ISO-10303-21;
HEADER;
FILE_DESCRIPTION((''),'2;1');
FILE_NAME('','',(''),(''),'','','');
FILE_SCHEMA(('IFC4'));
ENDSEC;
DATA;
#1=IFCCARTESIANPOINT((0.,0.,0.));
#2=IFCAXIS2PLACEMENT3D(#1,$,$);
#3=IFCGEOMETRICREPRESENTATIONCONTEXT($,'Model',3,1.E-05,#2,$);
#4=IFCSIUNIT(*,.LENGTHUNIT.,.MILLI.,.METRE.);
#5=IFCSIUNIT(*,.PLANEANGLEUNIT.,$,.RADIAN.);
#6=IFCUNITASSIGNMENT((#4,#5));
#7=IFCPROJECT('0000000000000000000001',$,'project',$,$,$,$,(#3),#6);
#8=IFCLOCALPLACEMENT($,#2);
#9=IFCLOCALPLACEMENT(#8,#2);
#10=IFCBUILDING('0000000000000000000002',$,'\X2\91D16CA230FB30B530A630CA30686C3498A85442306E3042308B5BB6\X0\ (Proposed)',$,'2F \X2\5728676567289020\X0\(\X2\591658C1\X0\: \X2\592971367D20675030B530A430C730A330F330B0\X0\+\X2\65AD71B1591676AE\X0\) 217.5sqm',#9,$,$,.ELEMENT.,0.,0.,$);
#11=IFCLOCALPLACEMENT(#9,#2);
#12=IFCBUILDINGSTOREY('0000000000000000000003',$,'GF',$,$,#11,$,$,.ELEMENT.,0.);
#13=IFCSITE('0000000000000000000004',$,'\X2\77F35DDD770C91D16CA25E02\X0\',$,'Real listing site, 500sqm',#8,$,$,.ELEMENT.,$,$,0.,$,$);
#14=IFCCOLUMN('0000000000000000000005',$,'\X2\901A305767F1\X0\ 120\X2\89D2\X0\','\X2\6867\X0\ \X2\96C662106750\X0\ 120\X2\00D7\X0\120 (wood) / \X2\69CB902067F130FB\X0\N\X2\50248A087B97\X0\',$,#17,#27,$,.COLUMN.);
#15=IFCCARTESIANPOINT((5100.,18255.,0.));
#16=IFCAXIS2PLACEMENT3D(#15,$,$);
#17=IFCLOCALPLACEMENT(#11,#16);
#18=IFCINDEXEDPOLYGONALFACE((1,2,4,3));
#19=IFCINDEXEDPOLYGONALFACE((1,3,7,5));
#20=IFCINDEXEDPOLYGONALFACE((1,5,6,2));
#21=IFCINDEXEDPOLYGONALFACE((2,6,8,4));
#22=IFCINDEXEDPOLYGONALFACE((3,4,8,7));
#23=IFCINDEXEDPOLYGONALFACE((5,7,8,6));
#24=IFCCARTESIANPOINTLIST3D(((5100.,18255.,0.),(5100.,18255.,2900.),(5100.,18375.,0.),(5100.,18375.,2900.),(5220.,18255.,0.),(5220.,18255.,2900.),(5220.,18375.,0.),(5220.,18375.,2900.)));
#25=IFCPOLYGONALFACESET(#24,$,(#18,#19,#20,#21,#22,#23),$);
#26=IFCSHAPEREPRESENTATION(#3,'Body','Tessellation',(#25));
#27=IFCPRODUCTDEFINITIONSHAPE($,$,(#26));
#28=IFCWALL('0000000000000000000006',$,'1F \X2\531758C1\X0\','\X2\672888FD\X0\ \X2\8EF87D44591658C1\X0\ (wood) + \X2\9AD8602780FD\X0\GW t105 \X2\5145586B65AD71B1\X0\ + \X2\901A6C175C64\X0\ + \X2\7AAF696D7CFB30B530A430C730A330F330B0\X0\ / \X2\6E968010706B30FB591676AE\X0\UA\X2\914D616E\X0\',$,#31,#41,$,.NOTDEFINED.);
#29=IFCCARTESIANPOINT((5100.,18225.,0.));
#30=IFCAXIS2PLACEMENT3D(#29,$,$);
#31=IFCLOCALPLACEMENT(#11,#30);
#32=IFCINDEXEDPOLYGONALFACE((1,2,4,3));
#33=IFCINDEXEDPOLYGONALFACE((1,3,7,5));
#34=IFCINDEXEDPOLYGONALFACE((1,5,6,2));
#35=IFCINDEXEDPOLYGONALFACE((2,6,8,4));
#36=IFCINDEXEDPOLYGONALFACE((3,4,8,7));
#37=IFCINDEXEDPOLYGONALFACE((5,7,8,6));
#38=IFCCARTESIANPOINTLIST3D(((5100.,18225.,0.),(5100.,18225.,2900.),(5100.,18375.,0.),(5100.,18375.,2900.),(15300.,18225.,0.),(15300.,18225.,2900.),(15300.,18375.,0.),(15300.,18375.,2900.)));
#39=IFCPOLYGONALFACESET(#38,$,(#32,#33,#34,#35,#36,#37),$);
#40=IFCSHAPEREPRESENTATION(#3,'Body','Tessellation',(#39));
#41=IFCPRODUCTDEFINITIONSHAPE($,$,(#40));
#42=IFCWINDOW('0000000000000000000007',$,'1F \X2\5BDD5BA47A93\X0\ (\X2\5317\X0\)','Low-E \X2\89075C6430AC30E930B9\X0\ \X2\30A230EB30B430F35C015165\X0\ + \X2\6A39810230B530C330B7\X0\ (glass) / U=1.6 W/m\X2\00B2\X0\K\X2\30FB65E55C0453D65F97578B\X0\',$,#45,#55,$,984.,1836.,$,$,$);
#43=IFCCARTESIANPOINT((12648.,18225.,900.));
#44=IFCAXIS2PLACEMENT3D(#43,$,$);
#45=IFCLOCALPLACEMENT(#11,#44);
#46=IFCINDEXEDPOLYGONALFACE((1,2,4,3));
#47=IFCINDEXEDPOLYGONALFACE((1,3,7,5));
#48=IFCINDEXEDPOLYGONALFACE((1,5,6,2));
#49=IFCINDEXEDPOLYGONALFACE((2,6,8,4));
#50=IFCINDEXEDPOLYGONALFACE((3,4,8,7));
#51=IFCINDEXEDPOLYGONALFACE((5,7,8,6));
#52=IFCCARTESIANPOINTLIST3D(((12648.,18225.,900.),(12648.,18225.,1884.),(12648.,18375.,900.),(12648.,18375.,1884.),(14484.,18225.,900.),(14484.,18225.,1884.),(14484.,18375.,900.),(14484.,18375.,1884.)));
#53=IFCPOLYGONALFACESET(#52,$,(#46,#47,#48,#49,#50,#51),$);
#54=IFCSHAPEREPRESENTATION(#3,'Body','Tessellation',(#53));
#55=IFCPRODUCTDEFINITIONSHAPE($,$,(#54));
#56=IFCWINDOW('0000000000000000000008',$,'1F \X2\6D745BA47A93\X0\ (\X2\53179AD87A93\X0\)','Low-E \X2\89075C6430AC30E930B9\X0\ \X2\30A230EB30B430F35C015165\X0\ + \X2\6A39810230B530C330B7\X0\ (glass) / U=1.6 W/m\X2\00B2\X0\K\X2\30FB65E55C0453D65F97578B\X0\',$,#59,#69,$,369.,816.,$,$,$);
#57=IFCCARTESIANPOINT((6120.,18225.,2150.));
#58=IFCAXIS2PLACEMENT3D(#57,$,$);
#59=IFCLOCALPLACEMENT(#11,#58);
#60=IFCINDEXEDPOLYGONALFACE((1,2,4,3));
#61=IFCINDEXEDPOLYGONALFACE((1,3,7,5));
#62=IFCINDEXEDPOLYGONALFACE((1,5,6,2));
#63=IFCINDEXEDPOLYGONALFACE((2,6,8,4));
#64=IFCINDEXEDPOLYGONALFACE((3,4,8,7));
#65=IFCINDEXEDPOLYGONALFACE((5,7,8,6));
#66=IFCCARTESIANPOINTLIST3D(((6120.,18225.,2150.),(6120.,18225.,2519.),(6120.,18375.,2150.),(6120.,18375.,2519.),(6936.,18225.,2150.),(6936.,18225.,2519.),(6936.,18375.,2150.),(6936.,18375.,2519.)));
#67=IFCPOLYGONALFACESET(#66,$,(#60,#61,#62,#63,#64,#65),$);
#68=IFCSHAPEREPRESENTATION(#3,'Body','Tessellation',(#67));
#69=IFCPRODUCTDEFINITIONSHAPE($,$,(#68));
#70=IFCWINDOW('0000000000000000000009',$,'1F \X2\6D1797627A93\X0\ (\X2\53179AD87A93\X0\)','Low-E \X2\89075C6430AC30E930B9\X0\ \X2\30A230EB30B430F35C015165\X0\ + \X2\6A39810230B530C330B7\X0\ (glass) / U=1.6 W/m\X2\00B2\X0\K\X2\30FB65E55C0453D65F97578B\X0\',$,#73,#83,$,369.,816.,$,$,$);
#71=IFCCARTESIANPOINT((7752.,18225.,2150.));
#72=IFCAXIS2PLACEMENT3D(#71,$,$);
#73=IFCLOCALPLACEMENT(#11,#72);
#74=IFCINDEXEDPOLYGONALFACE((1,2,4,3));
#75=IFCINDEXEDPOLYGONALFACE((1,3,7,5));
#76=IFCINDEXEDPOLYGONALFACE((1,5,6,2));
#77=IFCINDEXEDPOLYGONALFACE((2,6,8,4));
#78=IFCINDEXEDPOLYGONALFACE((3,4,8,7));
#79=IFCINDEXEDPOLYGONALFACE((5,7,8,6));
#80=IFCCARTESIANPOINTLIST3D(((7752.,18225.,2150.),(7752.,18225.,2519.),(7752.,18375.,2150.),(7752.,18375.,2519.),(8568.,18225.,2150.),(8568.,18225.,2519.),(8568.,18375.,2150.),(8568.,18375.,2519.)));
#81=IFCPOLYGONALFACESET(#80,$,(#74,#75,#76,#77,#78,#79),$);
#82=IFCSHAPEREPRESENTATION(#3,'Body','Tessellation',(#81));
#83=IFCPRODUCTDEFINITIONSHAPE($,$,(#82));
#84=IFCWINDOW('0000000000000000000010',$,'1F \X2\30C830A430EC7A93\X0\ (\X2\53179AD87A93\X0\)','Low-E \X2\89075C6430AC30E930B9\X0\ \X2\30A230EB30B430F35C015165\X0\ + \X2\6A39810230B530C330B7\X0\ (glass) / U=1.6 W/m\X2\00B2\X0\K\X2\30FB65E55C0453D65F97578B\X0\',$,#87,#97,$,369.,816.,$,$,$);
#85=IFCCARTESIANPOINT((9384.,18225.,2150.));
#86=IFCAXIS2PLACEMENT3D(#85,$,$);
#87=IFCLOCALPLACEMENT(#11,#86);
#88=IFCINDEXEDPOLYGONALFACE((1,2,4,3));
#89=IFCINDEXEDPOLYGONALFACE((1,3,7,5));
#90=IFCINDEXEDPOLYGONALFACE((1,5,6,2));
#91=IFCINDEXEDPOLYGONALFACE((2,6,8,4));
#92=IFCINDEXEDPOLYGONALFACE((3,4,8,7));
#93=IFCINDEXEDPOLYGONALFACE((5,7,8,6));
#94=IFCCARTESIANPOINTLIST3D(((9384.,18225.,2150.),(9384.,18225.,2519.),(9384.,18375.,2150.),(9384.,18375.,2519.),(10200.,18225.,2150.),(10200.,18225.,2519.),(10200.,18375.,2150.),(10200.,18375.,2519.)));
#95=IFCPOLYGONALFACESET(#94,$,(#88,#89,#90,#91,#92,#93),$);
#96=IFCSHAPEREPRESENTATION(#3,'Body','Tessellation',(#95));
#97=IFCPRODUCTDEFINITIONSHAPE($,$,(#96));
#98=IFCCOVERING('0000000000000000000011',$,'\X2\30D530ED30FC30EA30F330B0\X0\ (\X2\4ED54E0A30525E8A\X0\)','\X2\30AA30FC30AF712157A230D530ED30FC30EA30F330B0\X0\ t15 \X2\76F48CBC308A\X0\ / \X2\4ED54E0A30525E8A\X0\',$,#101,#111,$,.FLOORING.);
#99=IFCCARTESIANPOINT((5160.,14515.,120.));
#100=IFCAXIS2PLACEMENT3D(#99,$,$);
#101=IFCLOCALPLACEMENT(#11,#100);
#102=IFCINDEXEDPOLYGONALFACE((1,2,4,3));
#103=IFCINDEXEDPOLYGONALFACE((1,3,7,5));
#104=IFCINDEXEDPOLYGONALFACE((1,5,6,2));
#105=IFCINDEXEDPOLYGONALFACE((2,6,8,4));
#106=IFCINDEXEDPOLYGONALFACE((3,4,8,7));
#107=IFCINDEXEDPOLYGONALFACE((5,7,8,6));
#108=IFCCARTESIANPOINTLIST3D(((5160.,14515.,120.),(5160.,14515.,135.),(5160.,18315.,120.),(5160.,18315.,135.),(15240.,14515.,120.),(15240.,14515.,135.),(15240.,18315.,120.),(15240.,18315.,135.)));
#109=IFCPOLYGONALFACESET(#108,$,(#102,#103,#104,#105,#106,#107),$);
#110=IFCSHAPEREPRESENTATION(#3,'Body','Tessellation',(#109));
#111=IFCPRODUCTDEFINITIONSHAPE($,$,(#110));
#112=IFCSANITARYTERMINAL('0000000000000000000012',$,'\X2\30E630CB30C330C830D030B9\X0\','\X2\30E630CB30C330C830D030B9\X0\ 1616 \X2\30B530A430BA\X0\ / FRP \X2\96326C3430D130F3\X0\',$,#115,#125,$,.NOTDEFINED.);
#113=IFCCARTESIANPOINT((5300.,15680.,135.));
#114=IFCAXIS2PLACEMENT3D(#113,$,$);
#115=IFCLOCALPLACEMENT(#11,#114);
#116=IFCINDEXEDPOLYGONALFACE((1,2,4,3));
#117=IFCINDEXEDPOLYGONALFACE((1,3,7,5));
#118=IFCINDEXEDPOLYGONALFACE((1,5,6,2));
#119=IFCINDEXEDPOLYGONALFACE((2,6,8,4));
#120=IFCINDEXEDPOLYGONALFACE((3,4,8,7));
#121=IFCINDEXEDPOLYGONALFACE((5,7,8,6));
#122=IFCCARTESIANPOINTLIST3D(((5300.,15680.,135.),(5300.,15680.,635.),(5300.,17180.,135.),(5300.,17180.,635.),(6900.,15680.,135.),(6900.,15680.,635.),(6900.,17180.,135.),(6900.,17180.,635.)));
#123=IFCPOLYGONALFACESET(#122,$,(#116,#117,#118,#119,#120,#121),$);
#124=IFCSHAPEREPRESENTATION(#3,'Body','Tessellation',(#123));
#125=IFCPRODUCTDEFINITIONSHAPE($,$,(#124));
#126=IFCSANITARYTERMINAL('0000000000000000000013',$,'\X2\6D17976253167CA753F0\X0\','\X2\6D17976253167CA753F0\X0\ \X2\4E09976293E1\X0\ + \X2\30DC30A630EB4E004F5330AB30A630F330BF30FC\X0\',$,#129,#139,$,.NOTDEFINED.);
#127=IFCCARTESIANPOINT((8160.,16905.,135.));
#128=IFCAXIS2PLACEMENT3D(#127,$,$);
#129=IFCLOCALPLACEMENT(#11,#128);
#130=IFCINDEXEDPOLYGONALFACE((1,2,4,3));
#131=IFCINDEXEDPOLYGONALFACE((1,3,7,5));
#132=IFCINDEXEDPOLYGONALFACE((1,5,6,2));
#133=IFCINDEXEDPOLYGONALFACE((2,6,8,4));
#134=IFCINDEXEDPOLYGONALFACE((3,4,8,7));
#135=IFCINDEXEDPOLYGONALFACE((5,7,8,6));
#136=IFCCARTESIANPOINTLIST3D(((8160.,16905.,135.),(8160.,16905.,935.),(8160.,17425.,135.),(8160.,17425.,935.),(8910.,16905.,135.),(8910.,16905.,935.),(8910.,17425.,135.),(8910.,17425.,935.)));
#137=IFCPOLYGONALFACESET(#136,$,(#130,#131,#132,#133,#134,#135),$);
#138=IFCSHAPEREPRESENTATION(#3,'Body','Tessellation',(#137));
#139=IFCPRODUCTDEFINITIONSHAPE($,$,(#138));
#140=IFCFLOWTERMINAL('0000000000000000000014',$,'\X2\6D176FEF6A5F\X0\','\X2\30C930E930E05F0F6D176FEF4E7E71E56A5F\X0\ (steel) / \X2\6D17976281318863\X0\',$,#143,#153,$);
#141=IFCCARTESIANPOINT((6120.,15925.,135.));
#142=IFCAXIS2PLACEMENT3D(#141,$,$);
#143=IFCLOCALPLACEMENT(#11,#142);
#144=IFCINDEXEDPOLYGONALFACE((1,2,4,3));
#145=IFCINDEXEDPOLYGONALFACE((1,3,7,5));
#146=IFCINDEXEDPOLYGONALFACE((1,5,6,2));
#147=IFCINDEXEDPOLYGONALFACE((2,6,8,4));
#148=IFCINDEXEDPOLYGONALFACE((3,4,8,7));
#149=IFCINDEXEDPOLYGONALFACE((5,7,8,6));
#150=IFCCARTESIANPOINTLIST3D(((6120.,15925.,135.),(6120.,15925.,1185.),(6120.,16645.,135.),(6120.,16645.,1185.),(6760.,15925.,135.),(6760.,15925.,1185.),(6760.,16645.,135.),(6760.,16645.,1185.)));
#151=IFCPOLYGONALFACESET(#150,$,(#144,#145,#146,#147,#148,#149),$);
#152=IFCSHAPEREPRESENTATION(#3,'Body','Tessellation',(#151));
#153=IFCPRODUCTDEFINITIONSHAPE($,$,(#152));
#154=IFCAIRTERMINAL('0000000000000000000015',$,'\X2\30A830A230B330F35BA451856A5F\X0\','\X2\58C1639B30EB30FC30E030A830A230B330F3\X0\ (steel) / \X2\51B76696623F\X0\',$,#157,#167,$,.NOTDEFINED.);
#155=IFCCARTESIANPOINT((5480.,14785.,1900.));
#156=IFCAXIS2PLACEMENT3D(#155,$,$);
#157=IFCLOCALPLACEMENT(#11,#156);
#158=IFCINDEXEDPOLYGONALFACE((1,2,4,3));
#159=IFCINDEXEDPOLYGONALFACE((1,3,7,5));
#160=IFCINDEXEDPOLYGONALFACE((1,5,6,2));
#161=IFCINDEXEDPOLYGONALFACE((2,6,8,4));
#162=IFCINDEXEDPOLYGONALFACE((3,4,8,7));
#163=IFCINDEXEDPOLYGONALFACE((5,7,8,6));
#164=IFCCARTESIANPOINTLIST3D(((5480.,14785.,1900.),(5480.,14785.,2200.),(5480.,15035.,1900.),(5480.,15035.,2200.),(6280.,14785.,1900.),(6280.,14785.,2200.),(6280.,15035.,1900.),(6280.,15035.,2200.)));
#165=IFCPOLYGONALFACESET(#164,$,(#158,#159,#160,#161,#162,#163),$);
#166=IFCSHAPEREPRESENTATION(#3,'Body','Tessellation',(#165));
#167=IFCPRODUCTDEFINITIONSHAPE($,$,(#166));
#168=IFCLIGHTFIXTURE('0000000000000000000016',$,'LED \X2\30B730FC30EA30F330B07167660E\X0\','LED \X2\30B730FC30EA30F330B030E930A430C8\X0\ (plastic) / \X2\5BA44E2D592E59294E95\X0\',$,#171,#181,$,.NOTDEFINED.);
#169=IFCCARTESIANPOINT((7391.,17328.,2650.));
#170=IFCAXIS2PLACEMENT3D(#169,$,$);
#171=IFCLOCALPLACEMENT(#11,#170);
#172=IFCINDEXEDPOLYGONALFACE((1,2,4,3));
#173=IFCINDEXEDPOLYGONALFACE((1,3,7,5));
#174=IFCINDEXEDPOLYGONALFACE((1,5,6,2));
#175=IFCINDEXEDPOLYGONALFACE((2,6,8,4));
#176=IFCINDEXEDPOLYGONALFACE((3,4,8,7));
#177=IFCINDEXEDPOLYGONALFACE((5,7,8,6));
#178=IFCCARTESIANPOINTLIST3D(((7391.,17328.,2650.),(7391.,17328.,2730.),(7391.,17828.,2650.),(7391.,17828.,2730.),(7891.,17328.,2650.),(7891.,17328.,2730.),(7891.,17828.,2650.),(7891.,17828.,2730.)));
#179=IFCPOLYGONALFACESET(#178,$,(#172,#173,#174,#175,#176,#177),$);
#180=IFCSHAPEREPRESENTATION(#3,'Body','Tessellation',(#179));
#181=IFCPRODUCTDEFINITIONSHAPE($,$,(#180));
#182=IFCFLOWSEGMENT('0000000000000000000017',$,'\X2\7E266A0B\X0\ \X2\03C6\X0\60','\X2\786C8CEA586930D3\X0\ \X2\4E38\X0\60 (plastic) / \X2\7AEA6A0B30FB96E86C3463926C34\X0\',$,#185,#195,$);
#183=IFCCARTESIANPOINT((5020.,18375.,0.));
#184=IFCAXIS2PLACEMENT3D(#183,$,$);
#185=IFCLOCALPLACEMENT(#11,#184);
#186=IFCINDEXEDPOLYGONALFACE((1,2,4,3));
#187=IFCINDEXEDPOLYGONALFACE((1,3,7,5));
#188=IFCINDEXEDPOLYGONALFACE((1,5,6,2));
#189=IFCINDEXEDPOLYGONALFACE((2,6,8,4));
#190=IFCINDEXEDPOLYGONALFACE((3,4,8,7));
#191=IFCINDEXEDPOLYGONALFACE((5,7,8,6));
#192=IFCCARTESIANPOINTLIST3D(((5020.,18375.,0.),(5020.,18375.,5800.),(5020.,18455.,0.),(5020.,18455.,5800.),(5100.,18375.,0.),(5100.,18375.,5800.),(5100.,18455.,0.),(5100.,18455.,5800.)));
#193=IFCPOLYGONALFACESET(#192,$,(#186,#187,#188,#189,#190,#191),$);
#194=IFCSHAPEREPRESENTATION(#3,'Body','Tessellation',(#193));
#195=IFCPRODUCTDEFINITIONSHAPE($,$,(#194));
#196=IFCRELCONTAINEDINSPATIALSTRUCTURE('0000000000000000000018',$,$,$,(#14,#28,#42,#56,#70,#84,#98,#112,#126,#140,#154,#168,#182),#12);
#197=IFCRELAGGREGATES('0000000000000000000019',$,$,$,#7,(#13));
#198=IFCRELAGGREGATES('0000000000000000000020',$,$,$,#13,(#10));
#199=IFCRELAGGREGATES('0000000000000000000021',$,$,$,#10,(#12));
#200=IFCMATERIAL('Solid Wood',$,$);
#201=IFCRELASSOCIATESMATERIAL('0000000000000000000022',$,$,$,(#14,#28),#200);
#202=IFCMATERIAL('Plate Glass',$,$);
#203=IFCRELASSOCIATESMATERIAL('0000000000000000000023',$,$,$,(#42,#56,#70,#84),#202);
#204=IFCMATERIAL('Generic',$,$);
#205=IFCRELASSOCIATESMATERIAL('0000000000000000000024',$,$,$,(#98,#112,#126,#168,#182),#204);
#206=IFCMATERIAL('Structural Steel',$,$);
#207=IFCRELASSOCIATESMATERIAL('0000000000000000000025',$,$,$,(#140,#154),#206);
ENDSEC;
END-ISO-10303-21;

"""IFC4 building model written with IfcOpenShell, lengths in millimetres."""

from ifc_helpers import new_model, si_unit, frame, frame_2d, origin, place, context, project, spatial, rectangle, extrude, material, element, fill, save


model = new_model("IFC4")

# Units and contexts
model_context = context("Model", 3, precision=1e-05, world=origin())
ifc_project = project(units=[si_unit("LENGTHUNIT", "METRE", prefix="MILLI"), si_unit("PLANEANGLEUNIT", "RADIAN")], contexts=[model_context])

# Site, building, storey
site_placement = place(None, origin())
site = spatial("IfcSite", under=ifc_project, at=site_placement, Name="石川県金沢市", ObjectType="Real listing site, 500sqm", CompositionType="ELEMENT", RefElevation=0.0)
building_placement = place(site_placement, origin())
building = spatial("IfcBuilding", under=site, at=building_placement, Name="金沢・サウナと水風呂のある家 (Proposed)", ObjectType="2F 在来木造(外壁: 天然素材サイディング+断熱外皮) 217.5sqm", CompositionType="ELEMENT", ElevationOfRefHeight=0.0, ElevationOfTerrain=0.0)
storey_placement = place(building_placement, origin())
storey = spatial("IfcBuildingStorey", under=building, at=storey_placement, Name="GF", CompositionType="ELEMENT", Elevation=0.0)

# Column
ifc_material_1 = material(Name="Solid Wood")
column_1_placement = place(storey_placement, frame((5100.0, 18255.0, 0.0)))
element("IfcColumn", 1, at=column_1_placement, inside=storey, material=ifc_material_1, Name="通し柱 120角", Description="桧 集成材 120×120 (wood) / 構造柱・N値計算", PredefinedType="COLUMN", context=model_context, shape_type="SweptSolid", body=[
    extrude(rectangle(XDim=120.0, YDim=120.0, at=frame_2d((60.0, 60.0))), frame((5100.0, 18255.0, 0.0)), (0.0, 0.0, 1.0), 2900.0),
])

# Wall, openings, windows
wall_1_placement = place(storey_placement, frame((5100.0, 18225.0, 0.0)))
wall_1 = element("IfcWall", 2, at=wall_1_placement, inside=storey, material=ifc_material_1, Name="1F 北壁", Description="木製 軸組外壁 (wood) + 高性能GW t105 充填断熱 + 通気層 + 窯業系サイディング / 準耐火・外皮UA配慮", PredefinedType="NOTDEFINED", context=model_context, shape_type="SweptSolid", body=[
    extrude(rectangle(XDim=10200.0, YDim=150.0, at=frame_2d((5100.0, 75.0))), frame((5100.0, 18225.0, 0.0)), (0.0, 0.0, 1.0), 2900.0),
])
opening_1_placement = place(storey_placement, frame((12648.0, 18225.0, 900.0)))
opening_1 = element("IfcOpeningElement", 3, at=opening_1_placement, cuts=wall_1, PredefinedType="NOTDEFINED", context=model_context, shape_type="SweptSolid", body=[
    extrude(rectangle(XDim=1836.0, YDim=150.0, at=frame_2d((918.0, 75.0))), frame((12648.0, 18225.0, 900.0)), (0.0, 0.0, 1.0), 984.0),
])
opening_2_placement = place(storey_placement, frame((6120.0, 18225.0, 2150.0)))
opening_2 = element("IfcOpeningElement", 4, at=opening_2_placement, cuts=wall_1, PredefinedType="NOTDEFINED", context=model_context, shape_type="SweptSolid", body=[
    extrude(rectangle(XDim=816.0, YDim=150.0, at=frame_2d((408.0, 75.0))), frame((6120.0, 18225.0, 2150.0)), (0.0, 0.0, 1.0), 369.0),
])
opening_3_placement = place(storey_placement, frame((7752.0, 18225.0, 2150.0)))
opening_3 = element("IfcOpeningElement", 5, at=opening_3_placement, cuts=wall_1, PredefinedType="NOTDEFINED", context=model_context, shape_type="SweptSolid", body=[
    extrude(rectangle(XDim=816.0, YDim=150.0, at=frame_2d((408.0, 75.0))), frame((7752.0, 18225.0, 2150.0)), (0.0, 0.0, 1.0), 369.0),
])
opening_4_placement = place(storey_placement, frame((9384.0, 18225.0, 2150.0)))
opening_4 = element("IfcOpeningElement", 6, at=opening_4_placement, cuts=wall_1, PredefinedType="NOTDEFINED", context=model_context, shape_type="SweptSolid", body=[
    extrude(rectangle(XDim=816.0, YDim=150.0, at=frame_2d((408.0, 75.0))), frame((9384.0, 18225.0, 2150.0)), (0.0, 0.0, 1.0), 369.0),
])
ifc_material_2 = material(Name="Plate Glass")
window_1_placement = place(storey_placement, frame((12648.0, 18225.0, 900.0)))
window_1 = element("IfcWindow", 7, at=window_1_placement, inside=storey, material=ifc_material_2, Name="1F 寝室窓 (北)", Description="Low-E 複層ガラス アルゴン封入 + 樹脂サッシ (glass) / U=1.6 W/m²K・日射取得型", OverallHeight=984.0, OverallWidth=1836.0, context=model_context, shape_type="SweptSolid", body=[
    extrude(rectangle(XDim=1836.0, YDim=150.0, at=frame_2d((918.0, 75.0))), frame((12648.0, 18225.0, 900.0)), (0.0, 0.0, 1.0), 984.0),
])
fill(opening_1, window_1)
window_2_placement = place(storey_placement, frame((6120.0, 18225.0, 2150.0)))
window_2 = element("IfcWindow", 8, at=window_2_placement, inside=storey, material=ifc_material_2, Name="1F 浴室窓 (北高窓)", Description="Low-E 複層ガラス アルゴン封入 + 樹脂サッシ (glass) / U=1.6 W/m²K・日射取得型", OverallHeight=369.0, OverallWidth=816.0, context=model_context, shape_type="SweptSolid", body=[
    extrude(rectangle(XDim=816.0, YDim=150.0, at=frame_2d((408.0, 75.0))), frame((6120.0, 18225.0, 2150.0)), (0.0, 0.0, 1.0), 369.0),
])
fill(opening_2, window_2)
window_3_placement = place(storey_placement, frame((7752.0, 18225.0, 2150.0)))
window_3 = element("IfcWindow", 9, at=window_3_placement, inside=storey, material=ifc_material_2, Name="1F 洗面窓 (北高窓)", Description="Low-E 複層ガラス アルゴン封入 + 樹脂サッシ (glass) / U=1.6 W/m²K・日射取得型", OverallHeight=369.0, OverallWidth=816.0, context=model_context, shape_type="SweptSolid", body=[
    extrude(rectangle(XDim=816.0, YDim=150.0, at=frame_2d((408.0, 75.0))), frame((7752.0, 18225.0, 2150.0)), (0.0, 0.0, 1.0), 369.0),
])
fill(opening_3, window_3)
window_4_placement = place(storey_placement, frame((9384.0, 18225.0, 2150.0)))
window_4 = element("IfcWindow", 10, at=window_4_placement, inside=storey, material=ifc_material_2, Name="1F トイレ窓 (北高窓)", Description="Low-E 複層ガラス アルゴン封入 + 樹脂サッシ (glass) / U=1.6 W/m²K・日射取得型", OverallHeight=369.0, OverallWidth=816.0, context=model_context, shape_type="SweptSolid", body=[
    extrude(rectangle(XDim=816.0, YDim=150.0, at=frame_2d((408.0, 75.0))), frame((9384.0, 18225.0, 2150.0)), (0.0, 0.0, 1.0), 369.0),
])
fill(opening_4, window_4)

# Covering
ifc_material_3 = material(Name="Generic")
covering_placement = place(storey_placement, frame((5160.0, 14515.0, 120.0)))
element("IfcCovering", 11, at=covering_placement, inside=storey, material=ifc_material_3, Name="フローリング (仕上げ床)", Description="オーク無垢フローリング t15 直貼り / 仕上げ床", PredefinedType="FLOORING", context=model_context, shape_type="SweptSolid", body=[
    extrude(rectangle(XDim=10080.0, YDim=3800.0, at=frame_2d((5040.0, 1900.0))), frame((5160.0, 14515.0, 120.0)), (0.0, 0.0, 1.0), 15.0),
])

# Sanitary terminals
sanitary_terminal_1_placement = place(storey_placement, frame((5300.0, 15680.0, 135.0)))
element("IfcSanitaryTerminal", 12, at=sanitary_terminal_1_placement, inside=storey, material=ifc_material_3, Name="ユニットバス", Description="ユニットバス 1616 サイズ / FRP 防水パン", PredefinedType="NOTDEFINED", context=model_context, shape_type="SweptSolid", body=[
    extrude(rectangle(XDim=1600.0, YDim=1500.0, at=frame_2d((800.0, 750.0))), frame((5300.0, 15680.0, 135.0)), (0.0, 0.0, 1.0), 500.0),
])
sanitary_terminal_2_placement = place(storey_placement, frame((8160.0, 16905.0, 135.0)))
element("IfcSanitaryTerminal", 13, at=sanitary_terminal_2_placement, inside=storey, material=ifc_material_3, Name="洗面化粧台", Description="洗面化粧台 三面鏡 + ボウル一体カウンター", PredefinedType="NOTDEFINED", context=model_context, shape_type="SweptSolid", body=[
    extrude(rectangle(XDim=750.0, YDim=520.0, at=frame_2d((375.0, 260.0))), frame((8160.0, 16905.0, 135.0)), (0.0, 0.0, 1.0), 800.0),
])

# Flow terminal
ifc_material_4 = material(Name="Structural Steel")
flow_terminal_placement = place(storey_placement, frame((6120.0, 15925.0, 135.0)))
element("IfcFlowTerminal", 14, at=flow_terminal_placement, inside=storey, material=ifc_material_4, Name="洗濯機", Description="ドラム式洗濯乾燥機 (steel) / 洗面脱衣", context=model_context, shape_type="SweptSolid", body=[
    extrude(rectangle(XDim=640.0, YDim=720.0, at=frame_2d((320.0, 360.0))), frame((6120.0, 15925.0, 135.0)), (0.0, 0.0, 1.0), 1050.0),
])

# Air terminal
air_terminal_placement = place(storey_placement, frame((5480.0, 14785.0, 1900.0)))
element("IfcAirTerminal", 15, at=air_terminal_placement, inside=storey, material=ifc_material_4, Name="エアコン室内機", Description="壁掛ルームエアコン (steel) / 冷暖房", PredefinedType="NOTDEFINED", context=model_context, shape_type="SweptSolid", body=[
    extrude(rectangle(XDim=800.0, YDim=250.0, at=frame_2d((400.0, 125.0))), frame((5480.0, 14785.0, 1900.0)), (0.0, 0.0, 1.0), 300.0),
])

# Light fixture
light_fixture_placement = place(storey_placement, frame((7391.0, 17328.0, 2650.0)))
element("IfcLightFixture", 16, at=light_fixture_placement, inside=storey, material=ifc_material_3, Name="LED シーリング照明", Description="LED シーリングライト (plastic) / 室中央天井", PredefinedType="NOTDEFINED", context=model_context, shape_type="SweptSolid", body=[
    extrude(rectangle(XDim=500.0, YDim=500.0, at=frame_2d((250.0, 250.0))), frame((7391.0, 17328.0, 2650.0)), (0.0, 0.0, 1.0), 80.0),
])

# Flow segment
flow_segment_placement = place(storey_placement, frame((5020.0, 18375.0, 0.0)))
element("IfcFlowSegment", 17, at=flow_segment_placement, inside=storey, material=ifc_material_3, Name="縦樋 φ60", Description="硬質塩ビ 丸60 (plastic) / 竪樋・雨水排水", context=model_context, shape_type="SweptSolid", body=[
    extrude(rectangle(XDim=80.0, YDim=80.0, at=frame_2d((40.0, 40.0))), frame((5020.0, 18375.0, 0.0)), (0.0, 0.0, 1.0), 5800.0),
])

save(model, "model.ifc")
